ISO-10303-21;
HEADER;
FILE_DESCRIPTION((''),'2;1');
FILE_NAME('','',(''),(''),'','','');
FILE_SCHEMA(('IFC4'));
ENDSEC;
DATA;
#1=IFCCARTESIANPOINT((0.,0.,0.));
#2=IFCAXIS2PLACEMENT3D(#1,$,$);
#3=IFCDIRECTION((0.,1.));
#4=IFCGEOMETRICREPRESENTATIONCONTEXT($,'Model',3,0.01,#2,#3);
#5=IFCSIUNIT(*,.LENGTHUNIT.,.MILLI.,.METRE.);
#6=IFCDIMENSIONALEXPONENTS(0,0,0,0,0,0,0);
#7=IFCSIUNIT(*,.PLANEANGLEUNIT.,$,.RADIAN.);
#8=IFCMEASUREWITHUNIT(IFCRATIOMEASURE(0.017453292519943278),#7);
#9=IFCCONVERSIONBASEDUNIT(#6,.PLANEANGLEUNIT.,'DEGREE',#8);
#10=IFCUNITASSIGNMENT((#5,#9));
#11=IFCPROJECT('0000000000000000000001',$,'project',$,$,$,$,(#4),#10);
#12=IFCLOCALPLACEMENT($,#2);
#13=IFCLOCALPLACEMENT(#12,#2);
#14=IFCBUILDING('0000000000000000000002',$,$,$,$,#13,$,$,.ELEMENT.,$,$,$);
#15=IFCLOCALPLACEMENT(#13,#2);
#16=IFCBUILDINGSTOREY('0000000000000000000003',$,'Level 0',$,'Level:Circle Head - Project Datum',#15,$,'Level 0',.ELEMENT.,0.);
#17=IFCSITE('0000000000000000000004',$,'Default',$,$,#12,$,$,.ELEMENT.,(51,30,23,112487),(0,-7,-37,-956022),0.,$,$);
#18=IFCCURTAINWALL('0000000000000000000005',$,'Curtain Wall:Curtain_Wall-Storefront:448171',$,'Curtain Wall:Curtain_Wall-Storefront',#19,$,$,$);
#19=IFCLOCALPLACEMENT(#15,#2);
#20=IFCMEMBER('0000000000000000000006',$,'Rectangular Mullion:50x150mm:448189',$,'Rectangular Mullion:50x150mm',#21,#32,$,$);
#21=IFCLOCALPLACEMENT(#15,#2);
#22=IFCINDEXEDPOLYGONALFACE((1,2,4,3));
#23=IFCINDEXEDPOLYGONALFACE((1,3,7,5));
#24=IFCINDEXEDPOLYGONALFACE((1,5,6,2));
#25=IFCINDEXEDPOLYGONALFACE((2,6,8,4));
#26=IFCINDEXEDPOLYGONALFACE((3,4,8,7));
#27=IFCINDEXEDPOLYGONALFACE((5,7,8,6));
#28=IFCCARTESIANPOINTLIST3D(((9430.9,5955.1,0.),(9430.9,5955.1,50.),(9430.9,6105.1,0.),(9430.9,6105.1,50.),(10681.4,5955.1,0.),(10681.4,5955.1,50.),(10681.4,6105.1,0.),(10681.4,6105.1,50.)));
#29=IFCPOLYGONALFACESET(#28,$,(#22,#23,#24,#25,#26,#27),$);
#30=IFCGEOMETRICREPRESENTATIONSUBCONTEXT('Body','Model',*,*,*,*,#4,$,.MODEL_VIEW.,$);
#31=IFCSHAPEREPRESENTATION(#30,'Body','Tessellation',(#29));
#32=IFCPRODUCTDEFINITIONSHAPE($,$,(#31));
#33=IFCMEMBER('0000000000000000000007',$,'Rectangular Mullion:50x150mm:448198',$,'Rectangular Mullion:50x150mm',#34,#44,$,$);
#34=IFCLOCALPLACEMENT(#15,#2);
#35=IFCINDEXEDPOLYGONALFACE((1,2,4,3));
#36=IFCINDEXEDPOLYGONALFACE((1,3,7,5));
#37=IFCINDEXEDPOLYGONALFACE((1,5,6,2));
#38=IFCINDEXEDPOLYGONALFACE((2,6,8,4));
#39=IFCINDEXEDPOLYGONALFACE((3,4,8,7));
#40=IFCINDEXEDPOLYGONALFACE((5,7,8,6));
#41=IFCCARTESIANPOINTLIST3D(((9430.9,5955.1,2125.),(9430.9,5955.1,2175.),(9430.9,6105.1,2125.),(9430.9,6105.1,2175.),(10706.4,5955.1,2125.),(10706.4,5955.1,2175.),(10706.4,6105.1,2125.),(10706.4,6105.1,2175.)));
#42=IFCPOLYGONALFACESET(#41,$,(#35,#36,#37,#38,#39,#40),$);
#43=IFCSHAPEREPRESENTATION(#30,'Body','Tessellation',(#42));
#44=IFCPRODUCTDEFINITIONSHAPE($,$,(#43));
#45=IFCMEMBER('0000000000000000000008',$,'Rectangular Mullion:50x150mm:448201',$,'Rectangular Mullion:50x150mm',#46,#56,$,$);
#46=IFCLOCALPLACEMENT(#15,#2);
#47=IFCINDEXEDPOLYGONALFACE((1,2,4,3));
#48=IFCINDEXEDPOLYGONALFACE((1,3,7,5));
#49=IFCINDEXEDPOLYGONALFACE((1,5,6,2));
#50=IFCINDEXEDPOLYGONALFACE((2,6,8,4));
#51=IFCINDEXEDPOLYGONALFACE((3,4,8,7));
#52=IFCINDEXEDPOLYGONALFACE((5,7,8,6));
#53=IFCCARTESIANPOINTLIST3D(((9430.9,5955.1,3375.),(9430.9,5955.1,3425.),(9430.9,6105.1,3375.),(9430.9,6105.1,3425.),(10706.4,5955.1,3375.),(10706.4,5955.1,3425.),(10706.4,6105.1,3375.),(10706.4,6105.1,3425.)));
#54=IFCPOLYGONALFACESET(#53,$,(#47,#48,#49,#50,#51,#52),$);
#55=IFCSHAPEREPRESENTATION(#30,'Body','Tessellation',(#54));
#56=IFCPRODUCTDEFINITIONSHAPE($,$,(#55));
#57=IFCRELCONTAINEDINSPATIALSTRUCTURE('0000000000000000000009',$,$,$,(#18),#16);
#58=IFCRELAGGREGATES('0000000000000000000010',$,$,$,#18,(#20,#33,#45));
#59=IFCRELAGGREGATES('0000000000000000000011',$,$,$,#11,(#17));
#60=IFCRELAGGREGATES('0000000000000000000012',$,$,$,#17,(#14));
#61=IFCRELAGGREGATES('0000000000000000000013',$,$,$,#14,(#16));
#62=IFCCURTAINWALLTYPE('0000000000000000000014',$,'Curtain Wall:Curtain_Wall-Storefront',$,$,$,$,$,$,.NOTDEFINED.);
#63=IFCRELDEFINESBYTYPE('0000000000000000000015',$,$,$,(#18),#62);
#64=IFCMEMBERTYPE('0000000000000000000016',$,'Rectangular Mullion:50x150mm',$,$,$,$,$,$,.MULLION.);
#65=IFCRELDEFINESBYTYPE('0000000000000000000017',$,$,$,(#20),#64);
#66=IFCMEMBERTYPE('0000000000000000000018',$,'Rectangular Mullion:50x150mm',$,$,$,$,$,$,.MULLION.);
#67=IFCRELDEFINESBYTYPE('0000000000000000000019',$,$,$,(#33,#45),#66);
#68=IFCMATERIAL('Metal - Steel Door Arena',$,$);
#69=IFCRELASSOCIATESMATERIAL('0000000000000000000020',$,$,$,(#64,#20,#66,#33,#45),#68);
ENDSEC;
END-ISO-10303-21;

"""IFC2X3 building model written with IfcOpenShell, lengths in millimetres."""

from ifc_helpers import new_model, entity, si_unit, converted_unit, direction, frame, origin, origin_2d_with_axis, place, context, subcontext, project, spatial, rectangle, extrude, source, transform, mapped, material, type_object, type_shapes, element, aggregate, save


model = new_model("IFC2X3")

# Units and contexts
model_context = context("Model", 3, precision=0.01, world=origin(), true_north=direction((0.0, 1.0)))
body_context = subcontext(model_context, "Body", "Model", "MODEL_VIEW")
ifc_project = project(units=[si_unit("LENGTHUNIT", "METRE", prefix="MILLI"), converted_unit("PLANEANGLEUNIT", "DEGREE", entity("IfcRatioMeasure", 0.017453292519943278), si_unit("PLANEANGLEUNIT", "RADIAN"), dimensions=[0, 0, 0, 0, 0, 0, 0])], contexts=[model_context])

# Site, building, storey
site_placement = place(None, origin())
site = spatial("IfcSite", under=ifc_project, at=site_placement, Name="Default", CompositionType="ELEMENT", RefLatitude=(51, 30, 23, 112487), RefLongitude=(0, -7, -37, -956022), RefElevation=0.0)
building_placement = place(site_placement, origin())
building = spatial("IfcBuilding", under=site, at=building_placement, CompositionType="ELEMENT")
storey_placement = place(building_placement, origin())
storey = spatial("IfcBuildingStorey", under=building, at=storey_placement, Name="Level 0", ObjectType="Level:Circle Head - Project Datum", LongName="Level 0", CompositionType="ELEMENT", Elevation=0.0)

# Curtain wall, members
curtain_wall_type = type_object("IfcCurtainWallType", Name="Curtain Wall:Curtain_Wall-Storefront", PredefinedType="NOTDEFINED")
curtain_wall_placement = place(storey_placement, origin())
curtain_wall = element("IfcCurtainWall", 1, at=curtain_wall_placement, inside=storey, type_object=curtain_wall_type, Name="Curtain Wall:Curtain_Wall-Storefront:448171", ObjectType="Curtain Wall:Curtain_Wall-Storefront")
ifc_material_1 = material(Name="Metal - Steel Door Arena")
member_type_1 = type_object("IfcMemberType", Name="Rectangular Mullion:50x150mm", PredefinedType="MULLION", material=ifc_material_1)
shared_shape_1 = source(origin(), body_context, "Body", "SweptSolid", [
    extrude(rectangle(XDim=150.0, YDim=50.0, at=origin_2d_with_axis()), frame((-25.0, 0.0, -1250.5), z_axis=(0.0, 0.0, 1.0), x_axis=(0.0, -1.0, 0.0)), (0.0, 0.0, 1.0), 1250.5),
])
type_shapes(member_type_1, [shared_shape_1])
member_1_placement = place(curtain_wall_placement, frame((10681.4, 6030.1, 0.0), z_axis=(1.0, 0.0, 0.0), x_axis=(0.0, 0.0, -1.0)))
member_1 = element("IfcMember", 2, at=member_1_placement, type_object=member_type_1, material=ifc_material_1, Name="Rectangular Mullion:50x150mm:448189", ObjectType="Rectangular Mullion:50x150mm", context=body_context, shape_type="MappedRepresentation", body=[
    mapped(shared_shape_1, transform((0.0, 0.0, 0.0), scale=1.0)),
])
member_type_2 = type_object("IfcMemberType", Name="Rectangular Mullion:50x150mm", PredefinedType="MULLION", material=ifc_material_1)
shared_shape_2 = source(origin(), body_context, "Body", "SweptSolid", [
    extrude(rectangle(XDim=150.0, YDim=50.0, at=origin_2d_with_axis()), frame((0.0, 0.0, -1275.5), z_axis=(0.0, 0.0, 1.0), x_axis=(0.0, -1.0, 0.0)), (0.0, 0.0, 1.0), 1275.5),
])
type_shapes(member_type_2, [shared_shape_2])
member_2_placement = place(curtain_wall_placement, frame((9430.9, 6030.1, 2150.0), z_axis=(-1.0, 0.0, 0.0), x_axis=(0.0, 0.0, 1.0)))
member_2 = element("IfcMember", 3, at=member_2_placement, type_object=member_type_2, material=ifc_material_1, Name="Rectangular Mullion:50x150mm:448198", ObjectType="Rectangular Mullion:50x150mm", context=body_context, shape_type="MappedRepresentation", body=[
    mapped(shared_shape_2, transform((0.0, 0.0, 0.0), scale=1.0)),
])
member_3_placement = place(curtain_wall_placement, frame((9430.9, 6030.1, 3400.0), z_axis=(-1.0, 0.0, 0.0), x_axis=(0.0, 0.0, 1.0)))
member_3 = element("IfcMember", 4, at=member_3_placement, type_object=member_type_2, material=ifc_material_1, Name="Rectangular Mullion:50x150mm:448201", ObjectType="Rectangular Mullion:50x150mm", context=body_context, shape_type="MappedRepresentation", body=[
    mapped(shared_shape_2, transform((0.0, 0.0, 0.0), scale=1.0)),
])
aggregate(curtain_wall, [member_1, member_2, member_3])

save(model, "model.ifc")
